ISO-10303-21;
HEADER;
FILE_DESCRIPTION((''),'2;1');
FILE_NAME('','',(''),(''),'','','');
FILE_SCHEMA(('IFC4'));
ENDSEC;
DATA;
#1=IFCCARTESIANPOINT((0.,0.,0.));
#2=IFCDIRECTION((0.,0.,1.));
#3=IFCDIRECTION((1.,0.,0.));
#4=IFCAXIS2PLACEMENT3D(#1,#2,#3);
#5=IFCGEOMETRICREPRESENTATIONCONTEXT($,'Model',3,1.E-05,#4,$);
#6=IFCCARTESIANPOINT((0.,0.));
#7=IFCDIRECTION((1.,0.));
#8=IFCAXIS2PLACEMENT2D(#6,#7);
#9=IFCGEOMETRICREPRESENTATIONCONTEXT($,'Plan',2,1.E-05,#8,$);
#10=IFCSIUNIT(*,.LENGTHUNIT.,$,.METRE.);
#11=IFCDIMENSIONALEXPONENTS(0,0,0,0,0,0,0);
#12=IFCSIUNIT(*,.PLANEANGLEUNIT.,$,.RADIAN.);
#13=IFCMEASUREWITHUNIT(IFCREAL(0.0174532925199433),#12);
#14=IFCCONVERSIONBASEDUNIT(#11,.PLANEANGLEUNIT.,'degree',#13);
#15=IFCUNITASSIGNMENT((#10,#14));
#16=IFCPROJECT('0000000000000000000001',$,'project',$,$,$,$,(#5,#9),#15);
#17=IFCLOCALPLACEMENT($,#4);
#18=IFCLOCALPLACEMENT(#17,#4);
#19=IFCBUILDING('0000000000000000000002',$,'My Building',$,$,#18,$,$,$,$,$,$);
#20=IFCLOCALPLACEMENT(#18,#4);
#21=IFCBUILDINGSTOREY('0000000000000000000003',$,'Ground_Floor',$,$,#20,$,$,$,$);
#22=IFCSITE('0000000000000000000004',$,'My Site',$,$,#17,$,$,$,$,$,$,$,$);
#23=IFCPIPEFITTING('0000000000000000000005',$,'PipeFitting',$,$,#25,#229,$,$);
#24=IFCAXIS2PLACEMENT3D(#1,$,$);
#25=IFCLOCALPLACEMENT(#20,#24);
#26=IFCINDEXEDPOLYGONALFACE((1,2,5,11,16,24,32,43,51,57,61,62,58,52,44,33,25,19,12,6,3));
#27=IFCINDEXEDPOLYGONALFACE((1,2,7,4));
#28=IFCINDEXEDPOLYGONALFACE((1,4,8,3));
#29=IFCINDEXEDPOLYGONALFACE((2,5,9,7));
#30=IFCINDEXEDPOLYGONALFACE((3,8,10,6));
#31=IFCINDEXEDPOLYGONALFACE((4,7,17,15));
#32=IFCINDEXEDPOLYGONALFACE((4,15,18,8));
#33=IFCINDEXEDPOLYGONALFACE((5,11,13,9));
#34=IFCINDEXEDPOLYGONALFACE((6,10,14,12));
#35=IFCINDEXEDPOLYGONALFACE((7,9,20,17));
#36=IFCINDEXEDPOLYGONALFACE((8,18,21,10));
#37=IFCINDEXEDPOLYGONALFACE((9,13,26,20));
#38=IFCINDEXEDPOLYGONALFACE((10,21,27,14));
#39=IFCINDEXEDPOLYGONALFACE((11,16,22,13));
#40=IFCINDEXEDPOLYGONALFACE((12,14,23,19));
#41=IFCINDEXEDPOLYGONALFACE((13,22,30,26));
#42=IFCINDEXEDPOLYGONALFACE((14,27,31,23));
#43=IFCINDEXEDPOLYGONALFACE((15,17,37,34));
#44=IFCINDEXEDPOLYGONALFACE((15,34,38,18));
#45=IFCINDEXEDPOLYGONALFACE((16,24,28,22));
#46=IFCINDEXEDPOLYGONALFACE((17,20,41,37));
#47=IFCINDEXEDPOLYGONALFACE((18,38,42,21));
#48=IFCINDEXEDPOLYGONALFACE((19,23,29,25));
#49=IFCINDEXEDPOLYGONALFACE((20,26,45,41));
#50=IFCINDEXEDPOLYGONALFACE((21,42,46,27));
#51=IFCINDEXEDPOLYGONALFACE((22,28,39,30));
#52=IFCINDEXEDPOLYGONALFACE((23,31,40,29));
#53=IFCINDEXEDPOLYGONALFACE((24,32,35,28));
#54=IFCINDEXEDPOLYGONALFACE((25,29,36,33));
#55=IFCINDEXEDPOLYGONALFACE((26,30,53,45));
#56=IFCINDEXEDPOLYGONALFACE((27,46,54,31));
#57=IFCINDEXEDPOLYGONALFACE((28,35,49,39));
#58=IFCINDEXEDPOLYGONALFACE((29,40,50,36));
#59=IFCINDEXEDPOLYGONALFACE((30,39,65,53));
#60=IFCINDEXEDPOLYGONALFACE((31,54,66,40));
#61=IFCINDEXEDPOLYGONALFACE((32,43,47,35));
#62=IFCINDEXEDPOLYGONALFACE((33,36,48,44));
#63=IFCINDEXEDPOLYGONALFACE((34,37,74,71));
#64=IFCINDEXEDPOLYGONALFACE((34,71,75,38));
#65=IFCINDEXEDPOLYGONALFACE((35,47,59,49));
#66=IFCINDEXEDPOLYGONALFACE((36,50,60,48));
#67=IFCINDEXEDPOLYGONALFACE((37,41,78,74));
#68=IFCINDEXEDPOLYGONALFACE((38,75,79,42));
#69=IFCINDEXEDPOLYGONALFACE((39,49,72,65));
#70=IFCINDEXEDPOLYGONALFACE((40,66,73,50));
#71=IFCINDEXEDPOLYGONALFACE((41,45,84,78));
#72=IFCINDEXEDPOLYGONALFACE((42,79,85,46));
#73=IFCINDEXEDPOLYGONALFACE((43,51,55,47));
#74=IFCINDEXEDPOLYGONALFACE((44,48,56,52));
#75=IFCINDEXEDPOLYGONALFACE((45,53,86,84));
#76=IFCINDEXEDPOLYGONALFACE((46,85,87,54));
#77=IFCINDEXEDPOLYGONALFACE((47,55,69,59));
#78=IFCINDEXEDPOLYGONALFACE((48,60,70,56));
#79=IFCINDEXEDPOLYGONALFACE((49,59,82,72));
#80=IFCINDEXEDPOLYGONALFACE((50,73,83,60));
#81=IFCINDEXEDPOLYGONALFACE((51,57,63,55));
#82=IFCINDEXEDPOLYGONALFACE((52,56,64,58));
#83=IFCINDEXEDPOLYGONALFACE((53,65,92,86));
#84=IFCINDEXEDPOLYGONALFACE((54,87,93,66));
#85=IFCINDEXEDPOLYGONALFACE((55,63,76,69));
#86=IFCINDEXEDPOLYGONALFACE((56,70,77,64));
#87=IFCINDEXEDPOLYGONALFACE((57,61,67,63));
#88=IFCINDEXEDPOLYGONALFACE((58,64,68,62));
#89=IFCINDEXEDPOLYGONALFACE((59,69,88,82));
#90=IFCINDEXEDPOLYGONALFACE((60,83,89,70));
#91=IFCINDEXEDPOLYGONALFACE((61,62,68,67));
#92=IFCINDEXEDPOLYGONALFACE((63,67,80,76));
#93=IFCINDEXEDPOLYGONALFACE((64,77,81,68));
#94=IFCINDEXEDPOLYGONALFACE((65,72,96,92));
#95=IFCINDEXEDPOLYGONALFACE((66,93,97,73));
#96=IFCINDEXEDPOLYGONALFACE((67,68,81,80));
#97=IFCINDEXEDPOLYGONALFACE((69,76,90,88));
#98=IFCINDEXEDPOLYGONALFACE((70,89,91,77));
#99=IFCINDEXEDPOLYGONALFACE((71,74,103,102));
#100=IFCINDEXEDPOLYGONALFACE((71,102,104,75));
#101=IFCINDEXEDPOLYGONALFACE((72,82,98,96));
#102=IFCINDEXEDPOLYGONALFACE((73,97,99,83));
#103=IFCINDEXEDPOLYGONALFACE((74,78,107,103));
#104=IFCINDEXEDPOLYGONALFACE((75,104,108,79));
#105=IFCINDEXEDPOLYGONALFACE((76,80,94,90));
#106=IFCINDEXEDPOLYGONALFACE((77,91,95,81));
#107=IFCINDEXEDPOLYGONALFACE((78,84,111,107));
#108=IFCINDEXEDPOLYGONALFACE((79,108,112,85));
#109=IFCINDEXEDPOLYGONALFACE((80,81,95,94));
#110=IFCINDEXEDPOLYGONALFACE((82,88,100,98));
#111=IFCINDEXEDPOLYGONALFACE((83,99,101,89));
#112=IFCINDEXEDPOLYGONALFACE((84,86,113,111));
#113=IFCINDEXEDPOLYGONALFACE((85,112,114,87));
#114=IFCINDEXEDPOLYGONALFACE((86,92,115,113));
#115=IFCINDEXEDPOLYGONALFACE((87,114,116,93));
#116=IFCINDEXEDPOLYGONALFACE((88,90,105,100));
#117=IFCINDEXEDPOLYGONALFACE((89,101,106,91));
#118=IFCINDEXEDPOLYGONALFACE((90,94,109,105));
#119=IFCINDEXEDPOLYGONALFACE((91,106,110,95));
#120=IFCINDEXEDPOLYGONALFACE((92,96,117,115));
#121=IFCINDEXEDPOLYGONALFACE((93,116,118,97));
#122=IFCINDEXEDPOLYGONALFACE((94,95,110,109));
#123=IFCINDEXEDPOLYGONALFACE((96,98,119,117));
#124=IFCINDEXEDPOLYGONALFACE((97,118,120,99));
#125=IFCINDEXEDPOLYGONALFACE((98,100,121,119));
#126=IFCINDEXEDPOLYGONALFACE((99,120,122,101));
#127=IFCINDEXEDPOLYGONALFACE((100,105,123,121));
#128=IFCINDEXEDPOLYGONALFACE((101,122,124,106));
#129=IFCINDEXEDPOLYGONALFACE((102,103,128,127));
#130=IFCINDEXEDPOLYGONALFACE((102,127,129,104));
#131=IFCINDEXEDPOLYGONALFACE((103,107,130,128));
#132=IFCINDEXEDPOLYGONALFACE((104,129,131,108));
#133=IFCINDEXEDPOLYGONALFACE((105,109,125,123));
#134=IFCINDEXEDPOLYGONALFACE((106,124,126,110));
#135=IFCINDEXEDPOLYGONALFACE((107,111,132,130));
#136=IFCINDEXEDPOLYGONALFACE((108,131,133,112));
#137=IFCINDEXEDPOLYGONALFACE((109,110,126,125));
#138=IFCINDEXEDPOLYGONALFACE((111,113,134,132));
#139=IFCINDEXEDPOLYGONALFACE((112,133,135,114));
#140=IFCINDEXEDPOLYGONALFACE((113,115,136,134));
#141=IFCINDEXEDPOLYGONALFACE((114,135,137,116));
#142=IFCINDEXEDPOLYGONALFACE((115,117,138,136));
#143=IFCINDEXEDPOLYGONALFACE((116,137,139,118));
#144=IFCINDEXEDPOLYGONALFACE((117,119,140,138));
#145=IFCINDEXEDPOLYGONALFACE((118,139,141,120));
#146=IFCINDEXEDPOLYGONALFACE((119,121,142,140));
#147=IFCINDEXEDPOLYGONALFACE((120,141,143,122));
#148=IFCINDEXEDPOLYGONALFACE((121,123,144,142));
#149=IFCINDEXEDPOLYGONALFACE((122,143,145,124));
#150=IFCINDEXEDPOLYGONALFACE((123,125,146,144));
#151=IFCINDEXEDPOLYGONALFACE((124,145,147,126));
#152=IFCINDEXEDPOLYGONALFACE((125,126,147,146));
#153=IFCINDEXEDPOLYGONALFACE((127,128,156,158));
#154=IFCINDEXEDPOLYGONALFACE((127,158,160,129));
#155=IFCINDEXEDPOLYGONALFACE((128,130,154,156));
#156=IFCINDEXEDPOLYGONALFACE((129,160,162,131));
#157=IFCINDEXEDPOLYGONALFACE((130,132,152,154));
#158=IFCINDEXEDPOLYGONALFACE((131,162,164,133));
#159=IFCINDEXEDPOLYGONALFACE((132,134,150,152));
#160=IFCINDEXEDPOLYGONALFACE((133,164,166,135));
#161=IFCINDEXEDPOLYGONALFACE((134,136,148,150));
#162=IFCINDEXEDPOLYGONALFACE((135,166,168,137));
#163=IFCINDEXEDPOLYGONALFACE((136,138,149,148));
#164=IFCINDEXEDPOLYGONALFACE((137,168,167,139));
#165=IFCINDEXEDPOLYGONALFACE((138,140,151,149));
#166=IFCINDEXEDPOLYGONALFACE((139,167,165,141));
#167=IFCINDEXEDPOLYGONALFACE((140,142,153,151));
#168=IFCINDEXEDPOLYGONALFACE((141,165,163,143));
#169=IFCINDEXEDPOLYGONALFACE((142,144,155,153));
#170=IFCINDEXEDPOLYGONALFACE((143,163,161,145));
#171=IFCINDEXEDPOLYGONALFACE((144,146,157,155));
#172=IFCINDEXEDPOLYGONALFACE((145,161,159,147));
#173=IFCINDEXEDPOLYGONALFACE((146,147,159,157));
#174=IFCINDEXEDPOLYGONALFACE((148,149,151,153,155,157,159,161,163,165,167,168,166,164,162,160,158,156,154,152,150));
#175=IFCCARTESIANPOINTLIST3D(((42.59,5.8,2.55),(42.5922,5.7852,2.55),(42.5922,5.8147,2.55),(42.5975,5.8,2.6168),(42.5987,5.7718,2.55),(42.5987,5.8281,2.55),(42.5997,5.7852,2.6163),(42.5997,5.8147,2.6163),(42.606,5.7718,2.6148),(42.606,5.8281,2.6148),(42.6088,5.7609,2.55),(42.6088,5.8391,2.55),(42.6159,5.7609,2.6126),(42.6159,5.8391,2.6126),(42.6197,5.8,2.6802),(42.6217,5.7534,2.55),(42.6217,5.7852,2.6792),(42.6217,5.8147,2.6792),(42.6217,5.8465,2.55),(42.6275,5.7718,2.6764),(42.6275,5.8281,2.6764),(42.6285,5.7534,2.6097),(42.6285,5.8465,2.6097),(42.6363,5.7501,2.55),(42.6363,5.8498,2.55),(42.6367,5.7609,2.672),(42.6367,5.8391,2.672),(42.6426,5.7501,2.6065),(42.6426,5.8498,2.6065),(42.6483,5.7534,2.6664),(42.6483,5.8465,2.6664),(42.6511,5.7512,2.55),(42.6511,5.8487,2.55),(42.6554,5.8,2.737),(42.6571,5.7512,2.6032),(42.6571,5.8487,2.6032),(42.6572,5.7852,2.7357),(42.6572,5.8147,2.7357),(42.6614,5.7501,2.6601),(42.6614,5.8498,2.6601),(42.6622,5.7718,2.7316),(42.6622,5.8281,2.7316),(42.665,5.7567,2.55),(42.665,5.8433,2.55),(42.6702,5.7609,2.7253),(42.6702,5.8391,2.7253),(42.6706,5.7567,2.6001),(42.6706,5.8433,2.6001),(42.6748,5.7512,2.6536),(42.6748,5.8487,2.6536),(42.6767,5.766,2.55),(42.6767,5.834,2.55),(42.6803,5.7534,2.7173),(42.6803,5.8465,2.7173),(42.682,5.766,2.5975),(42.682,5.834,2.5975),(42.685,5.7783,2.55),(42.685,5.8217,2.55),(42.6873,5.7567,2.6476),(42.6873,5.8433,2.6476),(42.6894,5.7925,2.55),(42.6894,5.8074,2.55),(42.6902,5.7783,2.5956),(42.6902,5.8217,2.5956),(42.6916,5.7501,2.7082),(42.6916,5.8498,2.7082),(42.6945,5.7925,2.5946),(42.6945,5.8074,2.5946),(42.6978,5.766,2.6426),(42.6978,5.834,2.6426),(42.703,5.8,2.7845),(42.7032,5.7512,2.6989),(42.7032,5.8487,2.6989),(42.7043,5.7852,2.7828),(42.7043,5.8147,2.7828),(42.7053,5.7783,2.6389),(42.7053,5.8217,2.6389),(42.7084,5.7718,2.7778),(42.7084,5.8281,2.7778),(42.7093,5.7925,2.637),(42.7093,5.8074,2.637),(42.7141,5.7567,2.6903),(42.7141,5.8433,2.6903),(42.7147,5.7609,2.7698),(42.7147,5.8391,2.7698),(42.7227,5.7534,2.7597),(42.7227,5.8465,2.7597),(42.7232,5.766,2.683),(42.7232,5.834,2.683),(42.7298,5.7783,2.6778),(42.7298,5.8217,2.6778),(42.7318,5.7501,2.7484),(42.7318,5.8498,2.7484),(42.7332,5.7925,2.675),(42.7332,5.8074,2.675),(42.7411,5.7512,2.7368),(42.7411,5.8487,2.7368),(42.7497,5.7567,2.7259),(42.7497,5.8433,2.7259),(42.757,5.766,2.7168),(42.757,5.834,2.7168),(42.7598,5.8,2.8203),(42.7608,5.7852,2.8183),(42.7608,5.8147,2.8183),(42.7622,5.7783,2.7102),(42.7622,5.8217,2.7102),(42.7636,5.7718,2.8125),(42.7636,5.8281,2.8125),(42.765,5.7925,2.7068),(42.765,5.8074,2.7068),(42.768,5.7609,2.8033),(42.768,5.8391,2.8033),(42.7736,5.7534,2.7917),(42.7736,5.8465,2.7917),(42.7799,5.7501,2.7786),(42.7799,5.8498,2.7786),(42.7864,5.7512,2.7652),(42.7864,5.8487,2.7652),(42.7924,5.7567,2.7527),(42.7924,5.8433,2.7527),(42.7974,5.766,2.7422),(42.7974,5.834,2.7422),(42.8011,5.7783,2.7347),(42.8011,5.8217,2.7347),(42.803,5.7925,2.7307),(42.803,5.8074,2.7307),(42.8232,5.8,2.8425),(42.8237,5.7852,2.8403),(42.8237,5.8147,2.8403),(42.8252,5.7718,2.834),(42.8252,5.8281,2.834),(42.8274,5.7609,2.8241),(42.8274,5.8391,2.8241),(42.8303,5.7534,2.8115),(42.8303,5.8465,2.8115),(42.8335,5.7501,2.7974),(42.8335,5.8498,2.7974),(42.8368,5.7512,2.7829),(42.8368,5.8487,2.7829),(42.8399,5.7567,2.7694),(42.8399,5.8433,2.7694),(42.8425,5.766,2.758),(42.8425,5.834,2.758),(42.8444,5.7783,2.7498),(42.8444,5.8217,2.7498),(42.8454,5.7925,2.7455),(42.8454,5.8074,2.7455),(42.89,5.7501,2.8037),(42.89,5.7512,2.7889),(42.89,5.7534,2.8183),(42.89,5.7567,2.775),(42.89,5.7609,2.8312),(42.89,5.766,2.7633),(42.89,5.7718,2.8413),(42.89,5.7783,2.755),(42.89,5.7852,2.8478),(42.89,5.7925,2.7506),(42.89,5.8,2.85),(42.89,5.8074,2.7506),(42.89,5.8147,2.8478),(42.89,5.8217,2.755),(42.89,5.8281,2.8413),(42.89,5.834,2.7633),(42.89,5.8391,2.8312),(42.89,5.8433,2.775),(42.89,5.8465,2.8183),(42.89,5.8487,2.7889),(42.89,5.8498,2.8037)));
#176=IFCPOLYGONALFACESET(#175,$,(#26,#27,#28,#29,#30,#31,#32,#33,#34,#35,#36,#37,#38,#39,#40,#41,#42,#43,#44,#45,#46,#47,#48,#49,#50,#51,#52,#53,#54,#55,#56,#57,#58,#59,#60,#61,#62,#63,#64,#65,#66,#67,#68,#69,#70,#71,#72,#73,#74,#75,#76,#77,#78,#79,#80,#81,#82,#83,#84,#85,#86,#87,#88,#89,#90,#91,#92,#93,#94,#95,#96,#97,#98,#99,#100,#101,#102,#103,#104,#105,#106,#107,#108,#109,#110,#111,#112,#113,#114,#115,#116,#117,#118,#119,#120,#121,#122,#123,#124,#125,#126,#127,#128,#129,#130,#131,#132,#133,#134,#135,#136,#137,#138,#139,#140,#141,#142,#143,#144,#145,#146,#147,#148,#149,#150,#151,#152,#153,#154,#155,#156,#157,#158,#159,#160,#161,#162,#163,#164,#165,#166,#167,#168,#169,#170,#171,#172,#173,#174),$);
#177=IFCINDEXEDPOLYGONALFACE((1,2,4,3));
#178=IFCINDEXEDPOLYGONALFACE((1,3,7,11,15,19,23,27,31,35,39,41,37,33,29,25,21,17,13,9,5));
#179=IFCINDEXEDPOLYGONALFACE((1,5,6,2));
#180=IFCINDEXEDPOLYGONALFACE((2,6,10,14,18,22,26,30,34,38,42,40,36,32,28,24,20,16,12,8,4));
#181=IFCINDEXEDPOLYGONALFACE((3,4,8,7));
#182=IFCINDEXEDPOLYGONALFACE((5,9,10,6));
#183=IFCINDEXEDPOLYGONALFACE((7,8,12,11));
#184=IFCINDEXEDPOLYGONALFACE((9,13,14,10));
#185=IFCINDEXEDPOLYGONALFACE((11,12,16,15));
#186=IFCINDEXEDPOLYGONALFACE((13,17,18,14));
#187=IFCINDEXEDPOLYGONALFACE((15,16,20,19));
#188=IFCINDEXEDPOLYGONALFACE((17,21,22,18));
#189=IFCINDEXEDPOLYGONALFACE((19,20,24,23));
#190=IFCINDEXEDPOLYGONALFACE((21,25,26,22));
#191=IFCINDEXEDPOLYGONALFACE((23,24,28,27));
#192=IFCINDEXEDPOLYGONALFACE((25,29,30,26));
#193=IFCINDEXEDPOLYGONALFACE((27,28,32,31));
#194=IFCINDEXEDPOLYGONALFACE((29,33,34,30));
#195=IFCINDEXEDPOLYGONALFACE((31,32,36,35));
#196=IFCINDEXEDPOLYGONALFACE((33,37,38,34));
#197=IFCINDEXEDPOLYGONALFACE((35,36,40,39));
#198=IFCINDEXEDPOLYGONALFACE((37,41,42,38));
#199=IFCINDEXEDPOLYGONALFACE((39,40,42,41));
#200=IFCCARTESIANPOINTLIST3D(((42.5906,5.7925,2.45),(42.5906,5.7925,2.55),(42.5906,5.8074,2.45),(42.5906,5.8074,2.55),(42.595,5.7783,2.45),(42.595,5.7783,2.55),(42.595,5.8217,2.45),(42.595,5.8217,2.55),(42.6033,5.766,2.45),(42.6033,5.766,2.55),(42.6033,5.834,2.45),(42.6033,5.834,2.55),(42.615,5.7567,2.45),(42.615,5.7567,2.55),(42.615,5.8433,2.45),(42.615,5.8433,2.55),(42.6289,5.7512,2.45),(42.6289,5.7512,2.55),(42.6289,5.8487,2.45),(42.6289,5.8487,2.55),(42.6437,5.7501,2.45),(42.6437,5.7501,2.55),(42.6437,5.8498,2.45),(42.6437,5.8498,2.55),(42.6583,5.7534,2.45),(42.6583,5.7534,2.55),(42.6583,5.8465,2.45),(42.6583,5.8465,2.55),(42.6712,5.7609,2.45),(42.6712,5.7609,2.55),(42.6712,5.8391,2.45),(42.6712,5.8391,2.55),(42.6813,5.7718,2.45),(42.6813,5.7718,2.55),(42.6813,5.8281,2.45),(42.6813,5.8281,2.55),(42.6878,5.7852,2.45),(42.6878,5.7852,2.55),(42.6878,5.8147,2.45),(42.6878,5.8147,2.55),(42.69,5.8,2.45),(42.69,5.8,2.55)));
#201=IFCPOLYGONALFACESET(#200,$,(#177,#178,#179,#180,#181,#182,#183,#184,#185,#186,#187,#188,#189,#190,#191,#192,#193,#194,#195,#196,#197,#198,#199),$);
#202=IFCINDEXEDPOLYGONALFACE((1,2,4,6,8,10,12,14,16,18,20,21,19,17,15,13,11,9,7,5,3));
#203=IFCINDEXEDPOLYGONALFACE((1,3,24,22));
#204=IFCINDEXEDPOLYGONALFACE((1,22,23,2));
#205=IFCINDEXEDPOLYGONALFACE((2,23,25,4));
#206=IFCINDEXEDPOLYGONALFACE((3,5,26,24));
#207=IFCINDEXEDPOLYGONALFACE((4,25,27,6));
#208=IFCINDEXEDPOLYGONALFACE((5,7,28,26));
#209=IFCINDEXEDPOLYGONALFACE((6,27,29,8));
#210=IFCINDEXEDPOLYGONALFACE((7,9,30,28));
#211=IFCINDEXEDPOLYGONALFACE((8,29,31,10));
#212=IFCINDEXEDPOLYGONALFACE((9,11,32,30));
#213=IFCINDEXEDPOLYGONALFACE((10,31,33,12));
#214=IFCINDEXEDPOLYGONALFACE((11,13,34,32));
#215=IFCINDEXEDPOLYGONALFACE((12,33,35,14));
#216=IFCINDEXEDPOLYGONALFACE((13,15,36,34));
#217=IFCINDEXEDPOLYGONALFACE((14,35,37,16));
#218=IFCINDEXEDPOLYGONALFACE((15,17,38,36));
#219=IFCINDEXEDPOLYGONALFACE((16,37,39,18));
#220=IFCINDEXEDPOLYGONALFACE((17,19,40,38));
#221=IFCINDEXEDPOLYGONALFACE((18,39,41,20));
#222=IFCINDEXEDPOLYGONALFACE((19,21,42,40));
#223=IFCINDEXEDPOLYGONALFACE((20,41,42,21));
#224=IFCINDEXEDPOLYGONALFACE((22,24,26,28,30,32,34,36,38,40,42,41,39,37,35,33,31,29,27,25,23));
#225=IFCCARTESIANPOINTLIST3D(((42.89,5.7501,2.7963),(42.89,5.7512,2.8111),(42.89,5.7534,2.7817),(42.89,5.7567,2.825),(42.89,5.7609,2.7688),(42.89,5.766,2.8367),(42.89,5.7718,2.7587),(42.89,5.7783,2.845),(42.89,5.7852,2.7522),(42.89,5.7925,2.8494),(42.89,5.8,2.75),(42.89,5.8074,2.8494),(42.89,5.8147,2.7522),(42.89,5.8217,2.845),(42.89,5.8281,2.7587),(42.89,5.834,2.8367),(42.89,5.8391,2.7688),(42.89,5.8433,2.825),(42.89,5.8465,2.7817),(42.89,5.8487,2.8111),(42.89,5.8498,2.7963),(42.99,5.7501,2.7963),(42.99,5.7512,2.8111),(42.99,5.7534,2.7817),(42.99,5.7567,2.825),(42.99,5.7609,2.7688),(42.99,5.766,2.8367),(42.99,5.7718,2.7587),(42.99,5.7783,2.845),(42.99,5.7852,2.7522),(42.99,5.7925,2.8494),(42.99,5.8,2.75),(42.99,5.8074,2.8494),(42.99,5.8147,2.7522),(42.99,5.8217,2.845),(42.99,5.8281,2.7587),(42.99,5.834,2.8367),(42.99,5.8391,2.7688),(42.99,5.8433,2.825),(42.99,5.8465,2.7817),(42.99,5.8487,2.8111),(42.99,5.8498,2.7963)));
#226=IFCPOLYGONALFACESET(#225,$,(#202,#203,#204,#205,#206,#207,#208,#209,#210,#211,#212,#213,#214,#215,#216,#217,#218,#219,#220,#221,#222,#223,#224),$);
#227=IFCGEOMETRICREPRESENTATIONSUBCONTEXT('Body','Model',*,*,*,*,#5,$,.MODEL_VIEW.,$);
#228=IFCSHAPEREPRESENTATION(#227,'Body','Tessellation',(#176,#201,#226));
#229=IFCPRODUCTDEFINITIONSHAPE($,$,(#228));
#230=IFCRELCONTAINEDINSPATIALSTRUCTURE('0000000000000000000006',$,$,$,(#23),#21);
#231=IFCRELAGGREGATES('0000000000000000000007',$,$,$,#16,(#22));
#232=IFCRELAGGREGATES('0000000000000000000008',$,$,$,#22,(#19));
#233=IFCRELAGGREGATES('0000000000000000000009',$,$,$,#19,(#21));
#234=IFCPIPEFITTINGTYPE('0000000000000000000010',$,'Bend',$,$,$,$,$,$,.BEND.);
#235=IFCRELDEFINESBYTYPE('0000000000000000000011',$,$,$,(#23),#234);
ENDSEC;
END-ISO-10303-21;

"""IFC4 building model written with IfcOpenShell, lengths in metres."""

from ifc_helpers import new_model, entity, si_unit, converted_unit, frame, origin_with_axes, origin_2d_with_axis, place, context, subcontext, project, spatial, circle, extrude, source, transform, mapped, type_object, type_shapes, element, save


model = new_model("IFC4")

# Units and contexts
model_context = context("Model", 3, precision=1e-05, world=origin_with_axes())
plan_context = context("Plan", 2, precision=1e-05, world=origin_2d_with_axis())
body_context = subcontext(model_context, "Body", "Model", "MODEL_VIEW")
ifc_project = project(units=[si_unit("LENGTHUNIT", "METRE"), converted_unit("PLANEANGLEUNIT", "degree", entity("IfcReal", 0.0174532925199433), si_unit("PLANEANGLEUNIT", "RADIAN"), dimensions=[0, 0, 0, 0, 0, 0, 0])], contexts=[model_context, plan_context])

# Site, building, storey
site_placement = place(None, origin_with_axes())
site = spatial("IfcSite", under=ifc_project, at=site_placement, Name="My Site")
building_placement = place(site_placement, origin_with_axes())
building = spatial("IfcBuilding", under=site, at=building_placement, Name="My Building")
storey_placement = place(building_placement, origin_with_axes())
storey = spatial("IfcBuildingStorey", under=building, at=storey_placement, Name="Ground_Floor")

# Pipe fitting
pipe_fitting_type = type_object("IfcPipeFittingType", Name="Bend", PredefinedType="BEND")
shared_shape_1 = source(origin_with_axes(), body_context, "Body", "SolidModel", [
    entity("IfcSweptDiskSolid", entity("IfcIndexedPolyCurve", entity("IfcCartesianPointList3D", [[0.0, 0.0, -0.1], [0.0732, 0.0, -0.2768], [0.25, 0.0, -0.35]]), [entity("IfcArcIndex", [1, 2, 3])]), 0.05),
    extrude(circle(Radius=0.05), origin_with_axes(), (0.0, 0.0, -1.0), 0.1),
    extrude(circle(Radius=0.05), frame((0.25, 0.0, -0.35), z_axis=(1.0, 0.0, 0.0), x_axis=(0.0, 0.0, 1.0)), (0.0, 0.0, 1.0), 0.1),
])
type_shapes(pipe_fitting_type, [shared_shape_1])
for number, where, z_axis, x_axis, name in (
    (1, (42.64, 5.8, 2.45), (0.0, 0.000001, -1.0), (1.0, -0.000001, 0.0), "PipeFitting"),
):
    element("IfcPipeFitting", number, at=place(storey_placement, frame(where, z_axis=z_axis, x_axis=x_axis)), inside=storey, type_object=pipe_fitting_type, Name=name, context=body_context, shape_type="MappedRepresentation", body=[
        mapped(shared_shape_1, transform((0.0, 0.0, 0.0), x_axis=(1.0, 0.0, 0.0), y_axis=(0.0, 1.0, 0.0), z_axis=(0.0, 0.0, 1.0), scale=1.0)),
    ])

save(model, "model.ifc")
